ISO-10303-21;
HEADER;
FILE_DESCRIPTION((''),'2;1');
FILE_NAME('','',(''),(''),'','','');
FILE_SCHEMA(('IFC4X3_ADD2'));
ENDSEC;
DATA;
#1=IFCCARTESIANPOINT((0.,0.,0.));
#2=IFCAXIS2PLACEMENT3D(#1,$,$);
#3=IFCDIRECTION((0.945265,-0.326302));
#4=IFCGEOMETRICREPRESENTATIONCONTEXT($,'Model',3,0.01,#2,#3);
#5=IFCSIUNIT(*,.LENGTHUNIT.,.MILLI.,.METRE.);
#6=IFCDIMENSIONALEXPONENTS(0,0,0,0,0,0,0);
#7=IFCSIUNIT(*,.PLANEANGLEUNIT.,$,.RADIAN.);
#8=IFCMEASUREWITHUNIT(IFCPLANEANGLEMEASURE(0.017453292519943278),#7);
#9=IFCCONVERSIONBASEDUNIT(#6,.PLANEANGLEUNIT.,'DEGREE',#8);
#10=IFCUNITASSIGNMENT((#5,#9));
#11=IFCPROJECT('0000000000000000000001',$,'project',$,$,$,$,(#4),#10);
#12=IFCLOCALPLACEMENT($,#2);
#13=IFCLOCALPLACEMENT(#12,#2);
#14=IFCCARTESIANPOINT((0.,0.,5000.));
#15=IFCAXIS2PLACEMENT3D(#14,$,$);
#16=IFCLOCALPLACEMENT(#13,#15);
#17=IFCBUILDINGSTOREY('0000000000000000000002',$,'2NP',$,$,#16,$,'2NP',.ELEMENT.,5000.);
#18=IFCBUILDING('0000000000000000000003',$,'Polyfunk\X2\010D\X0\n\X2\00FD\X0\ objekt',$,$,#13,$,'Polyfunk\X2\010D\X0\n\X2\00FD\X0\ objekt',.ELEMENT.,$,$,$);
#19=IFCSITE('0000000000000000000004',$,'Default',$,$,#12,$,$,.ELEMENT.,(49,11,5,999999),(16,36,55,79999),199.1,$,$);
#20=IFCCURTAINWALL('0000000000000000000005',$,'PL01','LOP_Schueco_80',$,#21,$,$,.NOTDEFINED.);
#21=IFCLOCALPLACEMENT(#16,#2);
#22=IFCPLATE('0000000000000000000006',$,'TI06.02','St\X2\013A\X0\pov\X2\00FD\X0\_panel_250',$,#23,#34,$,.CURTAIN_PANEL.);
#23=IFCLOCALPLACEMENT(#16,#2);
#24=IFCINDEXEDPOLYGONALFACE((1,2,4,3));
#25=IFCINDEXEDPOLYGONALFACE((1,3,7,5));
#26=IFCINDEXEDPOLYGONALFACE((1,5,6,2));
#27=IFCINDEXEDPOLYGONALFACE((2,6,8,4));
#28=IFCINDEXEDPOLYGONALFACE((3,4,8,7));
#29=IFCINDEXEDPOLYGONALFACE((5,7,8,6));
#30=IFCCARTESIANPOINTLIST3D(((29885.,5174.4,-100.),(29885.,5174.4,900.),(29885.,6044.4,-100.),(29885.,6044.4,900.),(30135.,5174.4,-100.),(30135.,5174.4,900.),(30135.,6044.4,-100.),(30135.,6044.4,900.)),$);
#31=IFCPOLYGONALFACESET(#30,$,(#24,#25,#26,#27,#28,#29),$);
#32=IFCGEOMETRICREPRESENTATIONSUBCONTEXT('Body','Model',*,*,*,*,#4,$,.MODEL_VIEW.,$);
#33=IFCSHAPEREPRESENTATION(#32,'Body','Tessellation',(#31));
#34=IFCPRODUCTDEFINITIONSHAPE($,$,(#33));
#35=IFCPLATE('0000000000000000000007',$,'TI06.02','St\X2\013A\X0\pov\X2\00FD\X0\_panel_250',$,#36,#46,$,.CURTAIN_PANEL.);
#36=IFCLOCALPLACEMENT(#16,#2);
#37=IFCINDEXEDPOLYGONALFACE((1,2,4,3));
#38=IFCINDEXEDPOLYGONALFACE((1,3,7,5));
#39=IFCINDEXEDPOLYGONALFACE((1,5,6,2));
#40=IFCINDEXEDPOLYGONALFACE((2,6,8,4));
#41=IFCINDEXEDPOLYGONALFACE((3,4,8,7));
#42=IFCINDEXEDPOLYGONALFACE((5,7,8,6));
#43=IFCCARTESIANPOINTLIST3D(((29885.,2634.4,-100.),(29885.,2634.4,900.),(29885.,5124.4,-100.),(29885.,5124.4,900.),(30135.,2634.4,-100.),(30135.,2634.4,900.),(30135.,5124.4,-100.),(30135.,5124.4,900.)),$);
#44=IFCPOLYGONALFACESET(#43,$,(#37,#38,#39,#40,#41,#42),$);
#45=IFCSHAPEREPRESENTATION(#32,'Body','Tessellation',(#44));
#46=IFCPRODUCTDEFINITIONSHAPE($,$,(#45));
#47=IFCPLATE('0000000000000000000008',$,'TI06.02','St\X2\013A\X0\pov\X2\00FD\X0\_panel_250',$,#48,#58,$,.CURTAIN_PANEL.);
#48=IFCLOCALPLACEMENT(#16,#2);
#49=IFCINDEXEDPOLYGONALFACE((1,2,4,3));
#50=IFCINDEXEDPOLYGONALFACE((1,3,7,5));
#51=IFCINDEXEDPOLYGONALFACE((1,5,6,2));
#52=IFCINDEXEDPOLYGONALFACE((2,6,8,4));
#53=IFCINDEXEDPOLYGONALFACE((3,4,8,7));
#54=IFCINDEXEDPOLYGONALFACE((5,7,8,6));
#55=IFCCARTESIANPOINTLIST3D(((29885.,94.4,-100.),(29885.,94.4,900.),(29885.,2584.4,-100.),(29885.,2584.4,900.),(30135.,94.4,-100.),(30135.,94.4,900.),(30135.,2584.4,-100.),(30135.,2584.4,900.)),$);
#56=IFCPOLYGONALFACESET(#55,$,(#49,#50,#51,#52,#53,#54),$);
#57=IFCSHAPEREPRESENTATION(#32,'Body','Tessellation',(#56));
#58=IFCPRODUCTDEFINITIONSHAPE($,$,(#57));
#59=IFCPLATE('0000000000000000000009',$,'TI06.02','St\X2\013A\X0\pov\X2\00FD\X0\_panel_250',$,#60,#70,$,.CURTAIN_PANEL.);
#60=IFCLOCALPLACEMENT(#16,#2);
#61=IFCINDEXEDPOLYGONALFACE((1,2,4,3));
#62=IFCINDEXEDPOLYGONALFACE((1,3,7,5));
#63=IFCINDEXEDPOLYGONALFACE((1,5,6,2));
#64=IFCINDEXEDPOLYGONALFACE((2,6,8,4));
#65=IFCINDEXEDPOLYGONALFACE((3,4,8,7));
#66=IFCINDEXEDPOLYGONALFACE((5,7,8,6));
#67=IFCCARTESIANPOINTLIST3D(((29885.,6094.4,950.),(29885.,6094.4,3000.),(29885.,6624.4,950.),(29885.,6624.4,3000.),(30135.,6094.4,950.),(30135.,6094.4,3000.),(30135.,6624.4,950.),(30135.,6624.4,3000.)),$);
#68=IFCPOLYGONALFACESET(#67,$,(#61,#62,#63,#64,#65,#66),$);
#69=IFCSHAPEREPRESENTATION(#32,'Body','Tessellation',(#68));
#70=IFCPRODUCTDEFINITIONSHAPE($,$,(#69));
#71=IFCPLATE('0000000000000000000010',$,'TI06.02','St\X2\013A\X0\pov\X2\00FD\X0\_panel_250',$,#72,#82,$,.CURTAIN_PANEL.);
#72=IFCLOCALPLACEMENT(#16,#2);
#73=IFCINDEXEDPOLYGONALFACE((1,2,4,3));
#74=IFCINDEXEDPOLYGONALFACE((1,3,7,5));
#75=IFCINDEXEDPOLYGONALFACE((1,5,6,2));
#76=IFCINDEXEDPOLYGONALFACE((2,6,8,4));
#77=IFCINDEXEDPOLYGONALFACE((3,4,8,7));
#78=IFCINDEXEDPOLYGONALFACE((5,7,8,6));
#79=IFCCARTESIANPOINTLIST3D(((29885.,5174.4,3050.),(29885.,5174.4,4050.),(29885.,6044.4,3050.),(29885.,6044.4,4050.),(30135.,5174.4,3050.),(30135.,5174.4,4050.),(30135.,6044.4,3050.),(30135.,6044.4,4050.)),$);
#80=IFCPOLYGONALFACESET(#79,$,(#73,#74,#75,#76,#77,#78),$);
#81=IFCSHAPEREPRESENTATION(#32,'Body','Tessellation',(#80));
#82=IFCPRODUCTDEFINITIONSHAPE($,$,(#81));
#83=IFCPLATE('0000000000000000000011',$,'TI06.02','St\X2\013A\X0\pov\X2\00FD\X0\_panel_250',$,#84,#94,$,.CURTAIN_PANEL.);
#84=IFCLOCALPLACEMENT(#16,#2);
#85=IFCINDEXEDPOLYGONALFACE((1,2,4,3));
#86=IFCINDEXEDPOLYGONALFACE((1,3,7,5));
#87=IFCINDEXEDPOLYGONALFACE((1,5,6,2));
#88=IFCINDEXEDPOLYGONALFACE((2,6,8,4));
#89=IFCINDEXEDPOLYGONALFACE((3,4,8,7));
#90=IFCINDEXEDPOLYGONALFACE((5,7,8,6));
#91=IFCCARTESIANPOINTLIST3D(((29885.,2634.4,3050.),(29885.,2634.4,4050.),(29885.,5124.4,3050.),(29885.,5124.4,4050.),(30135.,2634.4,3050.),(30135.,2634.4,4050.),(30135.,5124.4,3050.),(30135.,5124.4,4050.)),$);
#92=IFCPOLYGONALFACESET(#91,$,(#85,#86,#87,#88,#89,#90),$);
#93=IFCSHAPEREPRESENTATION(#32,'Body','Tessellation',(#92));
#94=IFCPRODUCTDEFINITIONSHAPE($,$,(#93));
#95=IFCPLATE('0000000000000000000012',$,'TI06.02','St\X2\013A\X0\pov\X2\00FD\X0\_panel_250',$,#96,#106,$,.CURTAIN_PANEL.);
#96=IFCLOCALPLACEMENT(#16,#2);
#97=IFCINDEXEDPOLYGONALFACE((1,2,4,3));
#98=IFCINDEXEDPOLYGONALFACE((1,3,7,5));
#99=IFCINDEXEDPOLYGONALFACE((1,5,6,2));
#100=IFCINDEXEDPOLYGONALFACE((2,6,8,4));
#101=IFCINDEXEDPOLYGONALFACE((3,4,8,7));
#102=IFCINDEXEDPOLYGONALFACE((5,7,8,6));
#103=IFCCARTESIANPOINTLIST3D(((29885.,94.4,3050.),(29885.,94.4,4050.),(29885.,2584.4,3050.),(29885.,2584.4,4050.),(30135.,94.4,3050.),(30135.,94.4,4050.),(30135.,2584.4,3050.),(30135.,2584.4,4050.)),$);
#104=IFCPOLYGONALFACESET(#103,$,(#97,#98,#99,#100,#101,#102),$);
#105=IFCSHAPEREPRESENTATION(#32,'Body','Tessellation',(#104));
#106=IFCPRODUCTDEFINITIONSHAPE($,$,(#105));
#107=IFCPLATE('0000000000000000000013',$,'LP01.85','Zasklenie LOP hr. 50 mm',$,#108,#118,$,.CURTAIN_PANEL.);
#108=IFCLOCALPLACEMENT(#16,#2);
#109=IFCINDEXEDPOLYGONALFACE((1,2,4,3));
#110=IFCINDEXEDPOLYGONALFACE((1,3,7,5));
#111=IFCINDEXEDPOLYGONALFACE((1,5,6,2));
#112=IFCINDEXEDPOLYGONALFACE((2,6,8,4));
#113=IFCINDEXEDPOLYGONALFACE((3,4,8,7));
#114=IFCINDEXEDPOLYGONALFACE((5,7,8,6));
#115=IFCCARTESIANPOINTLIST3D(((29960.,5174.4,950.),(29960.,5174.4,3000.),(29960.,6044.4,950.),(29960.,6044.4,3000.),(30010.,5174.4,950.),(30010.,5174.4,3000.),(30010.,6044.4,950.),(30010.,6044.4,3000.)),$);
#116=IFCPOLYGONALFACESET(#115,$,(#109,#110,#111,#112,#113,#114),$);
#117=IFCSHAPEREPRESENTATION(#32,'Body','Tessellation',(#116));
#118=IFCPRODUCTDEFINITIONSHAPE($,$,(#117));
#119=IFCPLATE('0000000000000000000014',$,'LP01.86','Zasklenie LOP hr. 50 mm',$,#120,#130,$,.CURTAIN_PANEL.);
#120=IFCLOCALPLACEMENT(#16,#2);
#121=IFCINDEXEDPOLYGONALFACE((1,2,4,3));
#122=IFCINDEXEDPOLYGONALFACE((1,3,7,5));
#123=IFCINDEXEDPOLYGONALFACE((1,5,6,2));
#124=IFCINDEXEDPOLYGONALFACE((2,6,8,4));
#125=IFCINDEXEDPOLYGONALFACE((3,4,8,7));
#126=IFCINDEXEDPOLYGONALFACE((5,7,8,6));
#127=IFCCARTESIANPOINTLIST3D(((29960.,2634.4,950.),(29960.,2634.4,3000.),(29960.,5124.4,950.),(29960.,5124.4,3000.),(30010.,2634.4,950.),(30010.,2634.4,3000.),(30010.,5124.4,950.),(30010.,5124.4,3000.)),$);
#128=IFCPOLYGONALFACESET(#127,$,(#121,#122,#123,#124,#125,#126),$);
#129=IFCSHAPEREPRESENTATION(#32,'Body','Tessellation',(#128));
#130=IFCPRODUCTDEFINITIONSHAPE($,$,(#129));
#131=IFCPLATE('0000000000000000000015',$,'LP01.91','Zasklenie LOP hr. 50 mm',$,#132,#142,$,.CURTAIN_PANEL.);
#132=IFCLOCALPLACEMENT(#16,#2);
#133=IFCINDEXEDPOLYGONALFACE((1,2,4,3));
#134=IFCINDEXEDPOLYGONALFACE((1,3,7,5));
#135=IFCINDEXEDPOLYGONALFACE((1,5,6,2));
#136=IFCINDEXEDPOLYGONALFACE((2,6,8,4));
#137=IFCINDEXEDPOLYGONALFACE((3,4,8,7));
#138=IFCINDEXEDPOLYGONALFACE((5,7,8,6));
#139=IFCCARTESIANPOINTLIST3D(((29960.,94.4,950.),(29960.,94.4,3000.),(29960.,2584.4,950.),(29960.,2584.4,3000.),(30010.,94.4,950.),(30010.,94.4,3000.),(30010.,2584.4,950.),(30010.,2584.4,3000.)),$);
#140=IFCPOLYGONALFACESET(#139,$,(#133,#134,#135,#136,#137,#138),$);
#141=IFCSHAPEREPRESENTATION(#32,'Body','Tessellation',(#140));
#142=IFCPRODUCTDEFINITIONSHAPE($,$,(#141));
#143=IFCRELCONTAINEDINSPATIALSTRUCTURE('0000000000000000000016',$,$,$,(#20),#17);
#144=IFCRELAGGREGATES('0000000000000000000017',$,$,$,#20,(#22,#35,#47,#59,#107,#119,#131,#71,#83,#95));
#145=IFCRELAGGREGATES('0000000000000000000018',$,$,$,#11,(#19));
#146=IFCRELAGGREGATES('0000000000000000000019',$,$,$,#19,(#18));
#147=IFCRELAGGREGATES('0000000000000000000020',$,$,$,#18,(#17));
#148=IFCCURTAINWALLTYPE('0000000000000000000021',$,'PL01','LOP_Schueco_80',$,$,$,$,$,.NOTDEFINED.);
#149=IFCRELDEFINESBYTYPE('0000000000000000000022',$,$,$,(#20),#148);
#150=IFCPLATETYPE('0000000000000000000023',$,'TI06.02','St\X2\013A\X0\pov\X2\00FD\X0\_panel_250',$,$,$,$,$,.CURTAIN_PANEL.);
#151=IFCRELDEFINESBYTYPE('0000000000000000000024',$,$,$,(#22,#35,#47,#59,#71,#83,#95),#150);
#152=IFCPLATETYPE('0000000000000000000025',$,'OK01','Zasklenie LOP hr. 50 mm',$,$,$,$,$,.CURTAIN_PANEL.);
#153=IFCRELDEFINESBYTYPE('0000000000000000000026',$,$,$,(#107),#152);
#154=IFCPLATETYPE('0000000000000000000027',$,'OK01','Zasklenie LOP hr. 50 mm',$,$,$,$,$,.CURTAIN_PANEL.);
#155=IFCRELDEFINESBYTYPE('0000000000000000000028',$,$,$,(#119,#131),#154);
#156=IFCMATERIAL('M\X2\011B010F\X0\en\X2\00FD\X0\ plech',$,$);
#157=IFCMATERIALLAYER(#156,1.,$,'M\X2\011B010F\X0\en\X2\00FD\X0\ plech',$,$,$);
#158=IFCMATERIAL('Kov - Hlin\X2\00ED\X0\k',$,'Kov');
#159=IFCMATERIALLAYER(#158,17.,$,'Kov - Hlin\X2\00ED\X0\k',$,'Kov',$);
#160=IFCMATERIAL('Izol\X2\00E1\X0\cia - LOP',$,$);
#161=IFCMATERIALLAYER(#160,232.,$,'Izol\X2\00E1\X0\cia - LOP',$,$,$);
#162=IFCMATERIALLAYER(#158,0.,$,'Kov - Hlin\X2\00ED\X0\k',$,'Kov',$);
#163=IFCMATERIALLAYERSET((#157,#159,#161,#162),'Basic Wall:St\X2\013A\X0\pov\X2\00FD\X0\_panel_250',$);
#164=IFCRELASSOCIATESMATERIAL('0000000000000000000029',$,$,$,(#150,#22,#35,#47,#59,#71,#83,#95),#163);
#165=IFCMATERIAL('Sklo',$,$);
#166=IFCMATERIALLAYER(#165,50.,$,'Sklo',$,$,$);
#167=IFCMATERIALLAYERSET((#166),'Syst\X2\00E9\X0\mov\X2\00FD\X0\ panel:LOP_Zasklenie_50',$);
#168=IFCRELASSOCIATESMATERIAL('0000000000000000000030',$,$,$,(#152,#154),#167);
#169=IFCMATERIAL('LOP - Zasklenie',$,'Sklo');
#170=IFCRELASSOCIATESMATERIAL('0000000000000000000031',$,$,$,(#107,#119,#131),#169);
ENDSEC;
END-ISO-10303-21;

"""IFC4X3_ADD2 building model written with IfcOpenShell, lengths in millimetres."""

from ifc_helpers import new_model, entity, si_unit, converted_unit, direction, frame, frame_2d, origin, origin_2d_with_axis, place, context, subcontext, project, spatial, rectangle, extrude, source, transform, mapped, material, layer, layer_set, layer_usage, type_object, type_shapes, element, aggregate, save


model = new_model("IFC4X3_ADD2")

# Units and contexts
model_context = context("Model", 3, precision=0.01, world=origin(), true_north=direction((0.945265, -0.326302)))
body_context = subcontext(model_context, "Body", "Model", "MODEL_VIEW")
ifc_project = project(units=[si_unit("LENGTHUNIT", "METRE", prefix="MILLI"), converted_unit("PLANEANGLEUNIT", "DEGREE", entity("IfcPlaneAngleMeasure", 0.017453292519943278), si_unit("PLANEANGLEUNIT", "RADIAN"), dimensions=[0, 0, 0, 0, 0, 0, 0])], contexts=[model_context])

# Site, building, storey
site_placement = place(None, origin())
site = spatial("IfcSite", under=ifc_project, at=site_placement, Name="Default", CompositionType="ELEMENT", RefLatitude=(49, 11, 5, 999999), RefLongitude=(16, 36, 55, 79999), RefElevation=199.1)
building_placement = place(site_placement, origin())
building = spatial("IfcBuilding", under=site, at=building_placement, Name="Polyfunkčný objekt", LongName="Polyfunkčný objekt", CompositionType="ELEMENT")
storey_placement = place(building_placement, frame((0.0, 0.0, 5000.0)))
storey = spatial("IfcBuildingStorey", under=building, at=storey_placement, Name="2NP", LongName="2NP", CompositionType="ELEMENT", Elevation=5000.0)

# Shared definitions
curtain_wall_type = type_object("IfcCurtainWallType", Name="PL01", Description="LOP_Schueco_80", PredefinedType="NOTDEFINED")

# Curtain wall
curtain_wall_1_placement = place(storey_placement, frame((0.0, 0.0, -5000.0)))
curtain_wall_1 = element("IfcCurtainWall", 1, at=curtain_wall_1_placement, inside=storey, type_object=curtain_wall_type, Name="PL01", Description="LOP_Schueco_80", PredefinedType="NOTDEFINED")

# Plates
ifc_material_1 = material(Name="Měďený plech")
ifc_layer_1 = layer(ifc_material_1, 1.0, Name="Měďený plech")
ifc_material_2 = material(Name="Kov - Hliník", Category="Kov")
ifc_layer_2 = layer(ifc_material_2, 17.0, Name="Kov - Hliník", Category="Kov")
ifc_material_3 = material(Name="Izolácia - LOP")
ifc_layer_3 = layer(ifc_material_3, 232.0, Name="Izolácia - LOP")
ifc_layer_4 = layer(ifc_material_2, 0.0, Name="Kov - Hliník", Category="Kov")
ifc_layer_set_1 = layer_set([ifc_layer_1, ifc_layer_2, ifc_layer_3, ifc_layer_4], Name="Basic Wall:Stĺpový_panel_250")
ifc_layer_usage_1 = layer_usage(ifc_layer_set_1, "AXIS2", "POSITIVE", -125.0)
plate_type_1 = type_object("IfcPlateType", Name="TI06.02", Description="Stĺpový_panel_250", PredefinedType="CURTAIN_PANEL", material=ifc_layer_set_1)
plate_1_placement = place(storey_placement, frame((30010.0, 6044.4, -100.0), z_axis=(0.0, 0.0, 1.0), x_axis=(0.0, -1.0, 0.0)))
plate_1 = element("IfcPlate", 2, at=plate_1_placement, type_object=plate_type_1, material=ifc_layer_usage_1, Name="TI06.02", Description="Stĺpový_panel_250", PredefinedType="CURTAIN_PANEL", context=body_context, shape_type="SweptSolid", body=[
    extrude(rectangle(XDim=250.0, YDim=870.0, at=frame_2d((0.0, 0.0), x_axis=(1.0, 0.0))), frame((435.0, 0.0, 0.0), z_axis=(0.0, 0.0, 1.0), x_axis=(0.0, 1.0, 0.0)), (0.0, 0.0, 1.0), 1000.0),
])
ifc_layer_usage_2 = layer_usage(ifc_layer_set_1, "AXIS2", "POSITIVE", -125.0)
plate_2_placement = place(storey_placement, frame((30010.0, 5124.4, -100.0), z_axis=(0.0, 0.0, 1.0), x_axis=(0.0, -1.0, 0.0)))
plate_2 = element("IfcPlate", 3, at=plate_2_placement, type_object=plate_type_1, material=ifc_layer_usage_2, Name="TI06.02", Description="Stĺpový_panel_250", PredefinedType="CURTAIN_PANEL", context=body_context, shape_type="SweptSolid", body=[
    extrude(rectangle(XDim=250.0, YDim=2490.0, at=frame_2d((0.0, 0.0), x_axis=(1.0, 0.0))), frame((1245.0, 0.0, 0.0), z_axis=(0.0, 0.0, 1.0), x_axis=(0.0, 1.0, 0.0)), (0.0, 0.0, 1.0), 1000.0),
])
ifc_layer_usage_3 = layer_usage(ifc_layer_set_1, "AXIS2", "POSITIVE", -125.0)
plate_3_placement = place(storey_placement, frame((30010.0, 2584.4, -100.0), z_axis=(0.0, 0.0, 1.0), x_axis=(0.0, -1.0, 0.0)))
plate_3 = element("IfcPlate", 4, at=plate_3_placement, type_object=plate_type_1, material=ifc_layer_usage_3, Name="TI06.02", Description="Stĺpový_panel_250", PredefinedType="CURTAIN_PANEL", context=body_context, shape_type="SweptSolid", body=[
    extrude(rectangle(XDim=250.0, YDim=2490.0, at=frame_2d((0.0, 0.0), x_axis=(1.0, 0.0))), frame((1245.0, 0.0, 0.0), z_axis=(0.0, 0.0, 1.0), x_axis=(0.0, 1.0, 0.0)), (0.0, 0.0, 1.0), 1000.0),
])
ifc_layer_usage_4 = layer_usage(ifc_layer_set_1, "AXIS2", "POSITIVE", -125.0)
plate_4_placement = place(storey_placement, frame((30010.0, 6624.4, 950.0), z_axis=(0.0, 0.0, 1.0), x_axis=(0.0, -1.0, 0.0)))
plate_4 = element("IfcPlate", 5, at=plate_4_placement, type_object=plate_type_1, material=ifc_layer_usage_4, Name="TI06.02", Description="Stĺpový_panel_250", PredefinedType="CURTAIN_PANEL", context=body_context, shape_type="SweptSolid", body=[
    extrude(rectangle(XDim=250.0, YDim=530.0, at=frame_2d((0.0, 0.0), x_axis=(1.0, 0.0))), frame((265.0, 0.0, 0.0), z_axis=(0.0, 0.0, 1.0), x_axis=(0.0, 1.0, 0.0)), (0.0, 0.0, 1.0), 2050.0),
])
ifc_layer_usage_5 = layer_usage(ifc_layer_set_1, "AXIS2", "POSITIVE", -125.0)
plate_5_placement = place(storey_placement, frame((30010.0, 6044.4, 3050.0), z_axis=(0.0, 0.0, 1.0), x_axis=(0.0, -1.0, 0.0)))
plate_5 = element("IfcPlate", 6, at=plate_5_placement, type_object=plate_type_1, material=ifc_layer_usage_5, Name="TI06.02", Description="Stĺpový_panel_250", PredefinedType="CURTAIN_PANEL", context=body_context, shape_type="SweptSolid", body=[
    extrude(rectangle(XDim=250.0, YDim=870.0, at=frame_2d((0.0, 0.0), x_axis=(1.0, 0.0))), frame((435.0, 0.0, 0.0), z_axis=(0.0, 0.0, 1.0), x_axis=(0.0, 1.0, 0.0)), (0.0, 0.0, 1.0), 1000.0),
])
ifc_layer_usage_6 = layer_usage(ifc_layer_set_1, "AXIS2", "POSITIVE", -125.0)
plate_6_placement = place(storey_placement, frame((30010.0, 5124.4, 3050.0), z_axis=(0.0, 0.0, 1.0), x_axis=(0.0, -1.0, 0.0)))
plate_6 = element("IfcPlate", 7, at=plate_6_placement, type_object=plate_type_1, material=ifc_layer_usage_6, Name="TI06.02", Description="Stĺpový_panel_250", PredefinedType="CURTAIN_PANEL", context=body_context, shape_type="SweptSolid", body=[
    extrude(rectangle(XDim=250.0, YDim=2490.0, at=frame_2d((0.0, 0.0), x_axis=(1.0, 0.0))), frame((1245.0, 0.0, 0.0), z_axis=(0.0, 0.0, 1.0), x_axis=(0.0, 1.0, 0.0)), (0.0, 0.0, 1.0), 1000.0),
])
ifc_layer_usage_7 = layer_usage(ifc_layer_set_1, "AXIS2", "POSITIVE", -125.0)
plate_7_placement = place(storey_placement, frame((30010.0, 2584.4, 3050.0), z_axis=(0.0, 0.0, 1.0), x_axis=(0.0, -1.0, 0.0)))
plate_7 = element("IfcPlate", 8, at=plate_7_placement, type_object=plate_type_1, material=ifc_layer_usage_7, Name="TI06.02", Description="Stĺpový_panel_250", PredefinedType="CURTAIN_PANEL", context=body_context, shape_type="SweptSolid", body=[
    extrude(rectangle(XDim=250.0, YDim=2490.0, at=frame_2d((0.0, 0.0), x_axis=(1.0, 0.0))), frame((1245.0, 0.0, 0.0), z_axis=(0.0, 0.0, 1.0), x_axis=(0.0, 1.0, 0.0)), (0.0, 0.0, 1.0), 1000.0),
])
ifc_material_4 = material(Name="LOP - Zasklenie", Category="Sklo")
ifc_material_5 = material(Name="Sklo")
ifc_layer_5 = layer(ifc_material_5, 50.0, Name="Sklo")
ifc_layer_set_2 = layer_set([ifc_layer_5], Name="Systémový panel:LOP_Zasklenie_50")
plate_type_2 = type_object("IfcPlateType", Name="OK01", Description="Zasklenie LOP hr. 50 mm", PredefinedType="CURTAIN_PANEL", material=ifc_layer_set_2)
shared_shape_1 = source(origin(), body_context, "Body", "SweptSolid", [
    extrude(rectangle(XDim=50.0, YDim=870.0, at=origin_2d_with_axis()), frame((0.0, -25.0, 0.0), z_axis=(0.0, 0.0, 1.0), x_axis=(0.0, 1.0, 0.0)), (0.0, 0.0, 1.0), 2050.0),
])
type_shapes(plate_type_2, [shared_shape_1])
plate_8_placement = place(curtain_wall_1_placement, frame((30010.0, 5609.4, 5950.0), z_axis=(0.0, 0.0, 1.0), x_axis=(0.0, -1.0, 0.0)))
plate_8 = element("IfcPlate", 9, at=plate_8_placement, type_object=plate_type_2, material=ifc_material_4, Name="LP01.85", Description="Zasklenie LOP hr. 50 mm", PredefinedType="CURTAIN_PANEL", context=body_context, shape_type="MappedRepresentation", body=[
    mapped(shared_shape_1, transform((0.0, 0.0, 0.0), scale=1.0)),
])
plate_type_3 = type_object("IfcPlateType", Name="OK01", Description="Zasklenie LOP hr. 50 mm", PredefinedType="CURTAIN_PANEL", material=ifc_layer_set_2)
shared_shape_2 = source(origin(), body_context, "Body", "SweptSolid", [
    extrude(rectangle(XDim=50.0, YDim=2490.0, at=origin_2d_with_axis()), frame((0.0, -25.0, 0.0), z_axis=(0.0, 0.0, 1.0), x_axis=(0.0, 1.0, 0.0)), (0.0, 0.0, 1.0), 2050.0),
])
type_shapes(plate_type_3, [shared_shape_2])
plate_9_placement = place(curtain_wall_1_placement, frame((30010.0, 3879.4, 5950.0), z_axis=(0.0, 0.0, 1.0), x_axis=(0.0, -1.0, 0.0)))
plate_9 = element("IfcPlate", 10, at=plate_9_placement, type_object=plate_type_3, material=ifc_material_4, Name="LP01.86", Description="Zasklenie LOP hr. 50 mm", PredefinedType="CURTAIN_PANEL", context=body_context, shape_type="MappedRepresentation", body=[
    mapped(shared_shape_2, transform((0.0, 0.0, 0.0), scale=1.0)),
])
plate_10_placement = place(curtain_wall_1_placement, frame((30010.0, 1339.4, 5950.0), z_axis=(0.0, 0.0, 1.0), x_axis=(0.0, -1.0, 0.0)))
plate_10 = element("IfcPlate", 11, at=plate_10_placement, type_object=plate_type_3, material=ifc_material_4, Name="LP01.91", Description="Zasklenie LOP hr. 50 mm", PredefinedType="CURTAIN_PANEL", context=body_context, shape_type="MappedRepresentation", body=[
    mapped(shared_shape_2, transform((0.0, 0.0, 0.0), scale=1.0)),
])
aggregate(curtain_wall_1, [plate_1, plate_2, plate_3, plate_4, plate_8, plate_9, plate_10, plate_5, plate_6, plate_7])

save(model, "model.ifc")
